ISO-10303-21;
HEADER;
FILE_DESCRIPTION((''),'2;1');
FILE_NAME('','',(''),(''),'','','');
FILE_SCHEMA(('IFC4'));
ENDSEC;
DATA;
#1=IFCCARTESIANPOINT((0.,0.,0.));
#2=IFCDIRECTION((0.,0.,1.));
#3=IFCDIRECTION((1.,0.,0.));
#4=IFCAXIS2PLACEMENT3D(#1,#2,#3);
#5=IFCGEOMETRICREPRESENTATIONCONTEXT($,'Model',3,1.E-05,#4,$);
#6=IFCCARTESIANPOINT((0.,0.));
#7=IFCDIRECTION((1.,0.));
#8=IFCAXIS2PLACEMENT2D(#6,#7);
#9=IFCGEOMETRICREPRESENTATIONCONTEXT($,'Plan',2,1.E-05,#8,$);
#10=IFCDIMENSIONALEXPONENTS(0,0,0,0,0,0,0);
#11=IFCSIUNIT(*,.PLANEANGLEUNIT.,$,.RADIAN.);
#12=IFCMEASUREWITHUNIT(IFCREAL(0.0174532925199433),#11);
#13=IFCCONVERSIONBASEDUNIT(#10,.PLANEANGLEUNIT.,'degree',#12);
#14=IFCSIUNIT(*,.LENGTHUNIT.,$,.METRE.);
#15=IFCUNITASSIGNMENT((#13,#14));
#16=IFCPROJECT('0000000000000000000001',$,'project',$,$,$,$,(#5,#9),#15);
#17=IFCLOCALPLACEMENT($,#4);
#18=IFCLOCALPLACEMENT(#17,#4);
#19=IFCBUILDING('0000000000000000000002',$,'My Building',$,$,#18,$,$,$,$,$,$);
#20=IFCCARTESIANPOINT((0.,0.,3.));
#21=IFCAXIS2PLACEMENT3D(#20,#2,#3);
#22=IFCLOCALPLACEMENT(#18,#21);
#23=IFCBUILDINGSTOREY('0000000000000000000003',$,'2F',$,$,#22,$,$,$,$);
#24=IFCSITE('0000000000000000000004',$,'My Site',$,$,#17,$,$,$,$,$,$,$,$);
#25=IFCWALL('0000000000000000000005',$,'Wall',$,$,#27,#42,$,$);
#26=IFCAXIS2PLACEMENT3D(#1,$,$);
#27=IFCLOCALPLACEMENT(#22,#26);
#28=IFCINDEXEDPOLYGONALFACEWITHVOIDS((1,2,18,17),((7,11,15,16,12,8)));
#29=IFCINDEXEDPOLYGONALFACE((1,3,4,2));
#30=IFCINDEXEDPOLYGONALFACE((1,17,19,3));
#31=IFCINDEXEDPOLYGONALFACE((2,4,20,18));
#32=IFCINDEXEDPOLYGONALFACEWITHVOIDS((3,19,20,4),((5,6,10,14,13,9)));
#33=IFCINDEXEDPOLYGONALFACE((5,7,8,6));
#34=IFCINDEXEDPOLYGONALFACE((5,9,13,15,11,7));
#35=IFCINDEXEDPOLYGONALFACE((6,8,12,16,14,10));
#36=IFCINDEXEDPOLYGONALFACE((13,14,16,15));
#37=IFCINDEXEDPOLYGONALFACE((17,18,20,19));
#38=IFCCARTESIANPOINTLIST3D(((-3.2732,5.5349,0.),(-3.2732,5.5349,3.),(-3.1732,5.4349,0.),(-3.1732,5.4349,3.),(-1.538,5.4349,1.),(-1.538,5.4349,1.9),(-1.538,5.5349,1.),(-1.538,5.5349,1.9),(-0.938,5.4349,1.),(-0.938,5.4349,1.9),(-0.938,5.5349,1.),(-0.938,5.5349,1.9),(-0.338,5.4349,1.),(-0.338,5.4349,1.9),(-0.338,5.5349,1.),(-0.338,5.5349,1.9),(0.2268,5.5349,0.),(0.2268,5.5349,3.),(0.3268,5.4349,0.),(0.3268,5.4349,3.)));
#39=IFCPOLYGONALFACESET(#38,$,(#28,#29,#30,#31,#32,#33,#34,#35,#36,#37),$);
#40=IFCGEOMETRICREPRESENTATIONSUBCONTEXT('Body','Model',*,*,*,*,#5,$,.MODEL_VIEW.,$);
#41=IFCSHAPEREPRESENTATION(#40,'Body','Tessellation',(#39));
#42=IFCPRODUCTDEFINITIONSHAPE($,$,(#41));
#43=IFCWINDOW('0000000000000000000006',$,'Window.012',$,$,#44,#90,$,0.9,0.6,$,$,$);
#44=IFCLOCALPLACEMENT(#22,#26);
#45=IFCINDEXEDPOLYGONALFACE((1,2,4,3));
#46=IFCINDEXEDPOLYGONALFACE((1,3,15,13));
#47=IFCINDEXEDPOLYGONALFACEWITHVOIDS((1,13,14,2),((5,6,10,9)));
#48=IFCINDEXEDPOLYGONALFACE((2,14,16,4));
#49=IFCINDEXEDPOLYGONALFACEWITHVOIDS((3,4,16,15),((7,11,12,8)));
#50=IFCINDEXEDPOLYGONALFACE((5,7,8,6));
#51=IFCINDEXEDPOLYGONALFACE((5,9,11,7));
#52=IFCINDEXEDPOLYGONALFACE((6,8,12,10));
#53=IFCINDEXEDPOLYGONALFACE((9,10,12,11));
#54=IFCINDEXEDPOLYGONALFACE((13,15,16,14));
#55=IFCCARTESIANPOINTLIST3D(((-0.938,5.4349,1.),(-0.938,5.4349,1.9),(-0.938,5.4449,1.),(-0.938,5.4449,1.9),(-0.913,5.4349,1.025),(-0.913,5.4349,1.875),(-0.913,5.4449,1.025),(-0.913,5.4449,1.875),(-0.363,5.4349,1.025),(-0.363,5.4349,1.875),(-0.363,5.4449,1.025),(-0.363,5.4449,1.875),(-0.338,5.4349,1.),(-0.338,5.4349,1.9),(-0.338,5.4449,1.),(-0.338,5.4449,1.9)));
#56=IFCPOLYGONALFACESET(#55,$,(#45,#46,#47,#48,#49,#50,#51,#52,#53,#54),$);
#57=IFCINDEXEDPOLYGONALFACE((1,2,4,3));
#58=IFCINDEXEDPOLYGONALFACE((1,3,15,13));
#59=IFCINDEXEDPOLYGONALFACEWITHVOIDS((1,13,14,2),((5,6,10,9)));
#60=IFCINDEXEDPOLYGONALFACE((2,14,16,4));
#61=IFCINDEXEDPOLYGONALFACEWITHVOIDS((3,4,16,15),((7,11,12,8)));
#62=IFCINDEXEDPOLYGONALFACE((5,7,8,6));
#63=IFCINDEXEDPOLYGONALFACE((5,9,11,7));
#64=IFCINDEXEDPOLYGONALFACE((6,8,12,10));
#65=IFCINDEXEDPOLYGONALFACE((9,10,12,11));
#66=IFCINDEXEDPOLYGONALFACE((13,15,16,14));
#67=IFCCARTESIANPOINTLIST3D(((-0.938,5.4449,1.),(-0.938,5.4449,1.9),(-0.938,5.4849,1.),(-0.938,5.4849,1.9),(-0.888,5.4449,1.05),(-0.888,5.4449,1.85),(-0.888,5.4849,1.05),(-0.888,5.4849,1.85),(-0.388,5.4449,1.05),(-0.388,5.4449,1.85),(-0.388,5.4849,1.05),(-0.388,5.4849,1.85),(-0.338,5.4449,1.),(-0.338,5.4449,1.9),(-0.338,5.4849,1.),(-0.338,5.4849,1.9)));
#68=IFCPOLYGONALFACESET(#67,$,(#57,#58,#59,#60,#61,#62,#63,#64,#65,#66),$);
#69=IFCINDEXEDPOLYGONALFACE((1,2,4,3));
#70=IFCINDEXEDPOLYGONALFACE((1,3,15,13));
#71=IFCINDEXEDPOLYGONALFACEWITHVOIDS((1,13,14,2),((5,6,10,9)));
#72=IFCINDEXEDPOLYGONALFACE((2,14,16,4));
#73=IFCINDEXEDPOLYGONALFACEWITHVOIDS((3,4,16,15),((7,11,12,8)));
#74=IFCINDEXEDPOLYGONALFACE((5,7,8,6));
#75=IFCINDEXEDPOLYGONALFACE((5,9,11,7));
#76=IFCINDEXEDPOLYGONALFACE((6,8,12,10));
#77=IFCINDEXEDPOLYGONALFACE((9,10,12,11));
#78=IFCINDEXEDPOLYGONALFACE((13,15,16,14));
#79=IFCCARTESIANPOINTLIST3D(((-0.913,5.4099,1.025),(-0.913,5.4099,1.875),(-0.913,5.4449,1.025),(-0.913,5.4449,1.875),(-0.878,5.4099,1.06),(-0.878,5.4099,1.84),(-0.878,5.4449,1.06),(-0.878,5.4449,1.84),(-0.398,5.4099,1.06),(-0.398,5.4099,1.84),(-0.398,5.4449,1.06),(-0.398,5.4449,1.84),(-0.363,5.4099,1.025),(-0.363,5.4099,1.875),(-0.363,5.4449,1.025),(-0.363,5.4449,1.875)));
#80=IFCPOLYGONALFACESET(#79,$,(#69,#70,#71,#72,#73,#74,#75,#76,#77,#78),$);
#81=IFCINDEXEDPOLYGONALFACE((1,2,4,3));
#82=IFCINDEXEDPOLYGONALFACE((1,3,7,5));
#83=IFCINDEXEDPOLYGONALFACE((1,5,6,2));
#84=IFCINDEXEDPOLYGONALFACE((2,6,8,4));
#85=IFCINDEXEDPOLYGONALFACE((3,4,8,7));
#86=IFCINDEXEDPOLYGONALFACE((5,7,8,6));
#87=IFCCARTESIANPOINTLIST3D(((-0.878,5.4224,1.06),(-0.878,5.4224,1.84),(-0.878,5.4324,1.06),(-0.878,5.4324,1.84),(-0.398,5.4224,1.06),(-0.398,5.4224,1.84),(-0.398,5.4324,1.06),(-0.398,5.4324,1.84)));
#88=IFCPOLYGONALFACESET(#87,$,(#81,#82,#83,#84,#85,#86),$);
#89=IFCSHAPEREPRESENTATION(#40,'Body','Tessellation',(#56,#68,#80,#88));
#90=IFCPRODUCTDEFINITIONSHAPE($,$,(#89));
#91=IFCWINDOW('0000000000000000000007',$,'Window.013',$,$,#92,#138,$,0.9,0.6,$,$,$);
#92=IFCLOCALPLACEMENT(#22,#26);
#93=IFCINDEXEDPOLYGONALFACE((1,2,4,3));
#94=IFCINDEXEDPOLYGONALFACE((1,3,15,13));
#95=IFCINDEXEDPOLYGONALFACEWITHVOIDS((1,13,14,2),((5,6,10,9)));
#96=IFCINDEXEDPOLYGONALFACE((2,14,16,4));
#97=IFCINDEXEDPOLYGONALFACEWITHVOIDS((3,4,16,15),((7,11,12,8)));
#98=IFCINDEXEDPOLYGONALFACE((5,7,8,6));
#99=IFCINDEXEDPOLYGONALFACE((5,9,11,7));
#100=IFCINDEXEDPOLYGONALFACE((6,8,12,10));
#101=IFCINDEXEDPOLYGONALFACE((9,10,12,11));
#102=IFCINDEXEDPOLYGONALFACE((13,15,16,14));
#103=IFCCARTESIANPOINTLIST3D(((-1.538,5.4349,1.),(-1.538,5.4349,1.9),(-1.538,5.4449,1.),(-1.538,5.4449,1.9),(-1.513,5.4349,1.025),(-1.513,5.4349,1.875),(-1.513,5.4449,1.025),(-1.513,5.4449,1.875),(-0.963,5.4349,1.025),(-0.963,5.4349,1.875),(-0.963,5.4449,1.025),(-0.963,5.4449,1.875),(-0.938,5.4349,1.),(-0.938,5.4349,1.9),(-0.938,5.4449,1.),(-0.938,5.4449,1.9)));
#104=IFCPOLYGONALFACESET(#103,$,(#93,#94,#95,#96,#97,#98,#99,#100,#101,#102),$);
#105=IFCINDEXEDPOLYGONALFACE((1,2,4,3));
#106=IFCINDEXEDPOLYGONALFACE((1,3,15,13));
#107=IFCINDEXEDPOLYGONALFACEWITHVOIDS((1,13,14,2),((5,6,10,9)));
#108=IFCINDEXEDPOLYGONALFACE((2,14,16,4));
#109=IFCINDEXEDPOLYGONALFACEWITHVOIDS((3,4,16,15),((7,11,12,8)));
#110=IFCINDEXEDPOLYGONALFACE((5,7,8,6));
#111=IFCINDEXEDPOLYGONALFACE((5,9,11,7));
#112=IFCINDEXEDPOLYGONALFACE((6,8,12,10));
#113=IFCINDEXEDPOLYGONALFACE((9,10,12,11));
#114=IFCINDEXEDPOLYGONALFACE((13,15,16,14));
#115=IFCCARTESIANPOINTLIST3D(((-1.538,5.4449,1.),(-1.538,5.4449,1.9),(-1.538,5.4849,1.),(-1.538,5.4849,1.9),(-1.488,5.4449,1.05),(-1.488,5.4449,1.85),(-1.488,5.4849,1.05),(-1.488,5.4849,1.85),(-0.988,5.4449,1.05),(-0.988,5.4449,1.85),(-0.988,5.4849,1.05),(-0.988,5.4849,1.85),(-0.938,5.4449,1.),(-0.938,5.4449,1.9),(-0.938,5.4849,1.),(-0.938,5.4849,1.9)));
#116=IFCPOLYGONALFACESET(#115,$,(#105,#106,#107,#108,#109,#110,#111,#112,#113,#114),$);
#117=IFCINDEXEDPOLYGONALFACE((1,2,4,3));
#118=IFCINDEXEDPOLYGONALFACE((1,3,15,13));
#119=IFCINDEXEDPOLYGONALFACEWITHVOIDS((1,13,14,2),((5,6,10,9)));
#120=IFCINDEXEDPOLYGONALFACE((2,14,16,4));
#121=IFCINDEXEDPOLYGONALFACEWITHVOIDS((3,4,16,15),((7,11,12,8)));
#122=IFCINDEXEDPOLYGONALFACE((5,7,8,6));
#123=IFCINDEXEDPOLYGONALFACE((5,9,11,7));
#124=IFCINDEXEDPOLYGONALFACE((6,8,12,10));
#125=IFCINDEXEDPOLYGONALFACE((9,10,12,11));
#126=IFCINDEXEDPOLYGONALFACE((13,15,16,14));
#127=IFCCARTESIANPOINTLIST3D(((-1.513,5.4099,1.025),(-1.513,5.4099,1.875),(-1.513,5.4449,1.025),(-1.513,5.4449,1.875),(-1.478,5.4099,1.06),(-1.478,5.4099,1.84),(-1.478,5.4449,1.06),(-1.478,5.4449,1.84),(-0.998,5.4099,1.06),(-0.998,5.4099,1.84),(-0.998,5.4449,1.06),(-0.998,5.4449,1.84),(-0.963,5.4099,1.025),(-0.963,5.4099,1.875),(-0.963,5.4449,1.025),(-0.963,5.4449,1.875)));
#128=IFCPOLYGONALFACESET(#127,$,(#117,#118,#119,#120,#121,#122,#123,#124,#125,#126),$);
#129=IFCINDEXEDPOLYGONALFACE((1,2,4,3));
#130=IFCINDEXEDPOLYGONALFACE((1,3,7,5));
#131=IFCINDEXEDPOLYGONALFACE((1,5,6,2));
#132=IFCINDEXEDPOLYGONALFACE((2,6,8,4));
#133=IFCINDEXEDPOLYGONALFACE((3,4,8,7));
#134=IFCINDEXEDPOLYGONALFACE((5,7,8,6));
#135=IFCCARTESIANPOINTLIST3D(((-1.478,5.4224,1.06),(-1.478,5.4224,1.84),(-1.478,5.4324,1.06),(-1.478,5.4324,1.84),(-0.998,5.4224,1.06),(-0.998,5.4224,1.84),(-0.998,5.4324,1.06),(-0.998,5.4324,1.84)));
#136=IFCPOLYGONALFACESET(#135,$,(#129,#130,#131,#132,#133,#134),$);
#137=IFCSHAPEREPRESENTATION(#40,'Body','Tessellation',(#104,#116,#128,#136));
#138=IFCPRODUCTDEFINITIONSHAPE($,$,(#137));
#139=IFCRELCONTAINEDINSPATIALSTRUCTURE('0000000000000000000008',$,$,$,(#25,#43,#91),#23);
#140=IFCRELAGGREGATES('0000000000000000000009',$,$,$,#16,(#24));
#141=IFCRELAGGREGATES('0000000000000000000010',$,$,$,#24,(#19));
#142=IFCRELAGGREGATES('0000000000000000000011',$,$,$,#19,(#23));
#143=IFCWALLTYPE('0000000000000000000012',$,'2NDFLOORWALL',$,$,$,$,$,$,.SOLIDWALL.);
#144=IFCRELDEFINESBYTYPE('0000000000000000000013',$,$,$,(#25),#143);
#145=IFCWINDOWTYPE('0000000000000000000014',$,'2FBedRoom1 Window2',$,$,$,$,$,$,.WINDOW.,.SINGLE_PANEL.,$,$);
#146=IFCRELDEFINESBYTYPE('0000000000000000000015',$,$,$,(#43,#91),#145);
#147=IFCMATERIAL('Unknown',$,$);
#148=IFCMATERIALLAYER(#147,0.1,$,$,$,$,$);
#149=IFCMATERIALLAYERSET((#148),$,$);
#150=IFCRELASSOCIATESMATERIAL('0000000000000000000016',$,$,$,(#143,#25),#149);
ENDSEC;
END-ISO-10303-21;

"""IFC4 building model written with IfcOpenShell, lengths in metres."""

from ifc_helpers import new_model, entity, si_unit, converted_unit, frame, origin_with_axes, origin_2d_with_axis, place, context, subcontext, project, spatial, line, indexed_curve, outline, extrude, shape, source, transform, mapped, material, layer, layer_set, layer_usage, type_object, type_shapes, element, fill, save


model = new_model("IFC4")

# Units and contexts
model_context = context("Model", 3, precision=1e-05, world=origin_with_axes())
plan_context = context("Plan", 2, precision=1e-05, world=origin_2d_with_axis())
body_context_1 = subcontext(model_context, "Body", "Model", "MODEL_VIEW")
body_context_2 = subcontext(plan_context, "Body", "Plan", "PLAN_VIEW")
ifc_project = project(units=[converted_unit("PLANEANGLEUNIT", "degree", entity("IfcReal", 0.0174532925199433), si_unit("PLANEANGLEUNIT", "RADIAN"), dimensions=[0, 0, 0, 0, 0, 0, 0]), si_unit("LENGTHUNIT", "METRE")], contexts=[model_context, plan_context])

# Site, building, storey
site_placement = place(None, origin_with_axes())
site = spatial("IfcSite", under=ifc_project, at=site_placement, Name="My Site")
building_placement = place(site_placement, origin_with_axes())
building = spatial("IfcBuilding", under=site, at=building_placement, Name="My Building")
storey_placement = place(building_placement, frame((0.0, 0.0, 3.0), z_axis=(0.0, 0.0, 1.0), x_axis=(1.0, 0.0, 0.0)))
storey = spatial("IfcBuildingStorey", under=building, at=storey_placement, Name="2F")

# Shared definitions
ifc_material = material(Name="Unknown")

# Shared definitions
ifc_layer_1 = layer(ifc_material, 0.1)
ifc_layer_set_1 = layer_set([ifc_layer_1])
wall_type_1 = type_object("IfcWallType", Name="2NDFLOORWALL", PredefinedType="SOLIDWALL", material=ifc_layer_set_1)

# Wall, openings, windows
ifc_layer_usage_1 = layer_usage(ifc_layer_set_1, "AXIS2", "POSITIVE", 0.0)
wall_1_placement = place(storey_placement, frame((0.2268, 5.5349, 0.0), z_axis=(0.0, 0.0, 1.0), x_axis=(-1.0, 0.0, 0.0)))
wall_1 = element("IfcWall", 1, at=wall_1_placement, inside=storey, type_object=wall_type_1, material=ifc_layer_usage_1, Name="Wall", context=body_context_1, shape_type="SweptSolid", body=[
    extrude(outline(indexed_curve([(0.0, 0.0), (-0.1, 0.1), (3.4, 0.1), (3.5, 0.0)], segments=[line(1, 2, 3, 4, 1)])), origin_with_axes(), (0.0, 0.0, 1.0), 3.0),
])
shared_shape_1 = source(origin_with_axes(), body_context_1, "Body", "SweptSolid", [
    extrude(outline(indexed_curve([(0.0, 0.0), (0.6, 0.0), (0.6, 0.9), (0.0, 0.9)], segments=[line(1, 2, 3, 4, 1)])), frame((0.0, -0.6, 0.0), z_axis=(0.0, -1.0, 0.0), x_axis=(1.0, 0.0, 0.0)), (0.0, 0.0, -1.0), 1.2),
])
opening_1_placement = place(wall_1_placement, frame((0.5648, 0.0, 1.0), z_axis=(0.0, 0.0, 1.0), x_axis=(1.0, 0.0, 0.0)))
opening_1 = element("IfcOpeningElement", 2, at=opening_1_placement, cuts=wall_1, PredefinedType="OPENING", context=body_context_1, shape_type="MappedRepresentation", body=[
    mapped(shared_shape_1, transform((0.0, 0.0, 0.0), x_axis=(1.0, 0.0, 0.0), y_axis=(0.0, 1.0, 0.0), z_axis=(0.0, 0.0, 1.0), scale=1.0)),
])
opening_2_placement = place(wall_1_placement, frame((1.1648, 0.0, 1.0), z_axis=(0.0, 0.0, 1.0), x_axis=(1.0, 0.0, 0.0)))
opening_2 = element("IfcOpeningElement", 3, at=opening_2_placement, cuts=wall_1, PredefinedType="OPENING", context=body_context_1, shape_type="MappedRepresentation", body=[
    mapped(shared_shape_1, transform((0.0, 0.0, 0.0), x_axis=(1.0, 0.0, 0.0), y_axis=(0.0, 1.0, 0.0), z_axis=(0.0, 0.0, 1.0), scale=1.0)),
])
window_type_1 = type_object("IfcWindowType", Name="2FBedRoom1 Window2", PartitioningType="SINGLE_PANEL", PredefinedType="WINDOW")
shared_shape_2 = source(origin_with_axes(), body_context_1, "Body", "SweptSolid", [
    extrude(outline(indexed_curve([(0.0, 0.0), (0.6, 0.0), (0.6, 0.9), (0.0, 0.9)], segments=[line(1, 2, 3, 4, 1)]), holes=[indexed_curve([(0.025, 0.025), (0.575, 0.025), (0.575, 0.875), (0.025, 0.875)], segments=[line(1, 2, 3, 4, 1)])]), frame((0.0, 0.09, 0.0), z_axis=(0.0, -1.0, 0.0), x_axis=(1.0, 0.0, 0.0)), (0.0, 0.0, -1.0), 0.01),
    extrude(outline(indexed_curve([(0.0, 0.0), (0.6, 0.0), (0.6, 0.9), (0.0, 0.9)], segments=[line(1, 2, 3, 4, 1)]), holes=[indexed_curve([(0.05, 0.05), (0.55, 0.05), (0.55, 0.85), (0.05, 0.85)], segments=[line(1, 2, 3, 4, 1)])]), frame((0.0, 0.05, 0.0), z_axis=(0.0, -1.0, 0.0), x_axis=(1.0, 0.0, 0.0)), (0.0, 0.0, -1.0), 0.04),
    extrude(outline(indexed_curve([(0.0, 0.0), (0.55, 0.0), (0.55, 0.85), (0.0, 0.85)], segments=[line(1, 2, 3, 4, 1)]), holes=[indexed_curve([(0.035, 0.035), (0.515, 0.035), (0.515, 0.815), (0.035, 0.815)], segments=[line(1, 2, 3, 4, 1)])]), frame((0.025, 0.09, 0.025), z_axis=(0.0, -1.0, 0.0), x_axis=(1.0, 0.0, 0.0)), (0.0, 0.0, -1.0), 0.035),
    extrude(outline(indexed_curve([(0.035, 0.035), (0.515, 0.035), (0.515, 0.815), (0.035, 0.815)], segments=[line(1, 2, 3, 4, 1)])), frame((0.025, 0.1025, 0.025), z_axis=(0.0, -1.0, 0.0), x_axis=(1.0, 0.0, 0.0)), (0.0, 0.0, -1.0), 0.01),
])
shared_shape_3 = source(origin_with_axes(), body_context_2, "Body", "Curve2D", [
    entity("IfcIndexedPolyCurve", entity("IfcCartesianPointList2D", [[0.05, 0.05], [0.55, 0.05]])),
    entity("IfcIndexedPolyCurve", entity("IfcCartesianPointList2D", [[0.0, 0.1], [0.025, 0.1], [0.025, 0.09], [0.05, 0.09], [0.05, 0.05], [0.0, 0.05]]), [entity("IfcLineIndex", [1, 2, 3, 4, 5, 6, 1])]),
    entity("IfcIndexedPolyCurve", entity("IfcCartesianPointList2D", [[0.6, 0.1], [0.575, 0.1], [0.575, 0.09], [0.55, 0.09], [0.55, 0.05], [0.6, 0.05]]), [entity("IfcLineIndex", [1, 2, 3, 4, 5, 6, 1])]),
    entity("IfcIndexedPolyCurve", entity("IfcCartesianPointList2D", [[0.025, 0.09], [0.06, 0.09], [0.06, 0.125], [0.025, 0.125]]), [entity("IfcLineIndex", [1, 2, 3, 4, 1])]),
    entity("IfcIndexedPolyCurve", entity("IfcCartesianPointList2D", [[0.575, 0.09], [0.54, 0.09], [0.54, 0.125], [0.575, 0.125]]), [entity("IfcLineIndex", [1, 2, 3, 4, 1])]),
    entity("IfcIndexedPolyCurve", entity("IfcCartesianPointList2D", [[0.06, 0.09], [0.54, 0.09]])),
    entity("IfcIndexedPolyCurve", entity("IfcCartesianPointList2D", [[0.06, 0.125], [0.54, 0.125]])),
    entity("IfcIndexedPolyCurve", entity("IfcCartesianPointList2D", [[0.06, 0.1075], [0.54, 0.1075]])),
])
type_shapes(window_type_1, [shared_shape_2, shared_shape_3])
window_1_placement = place(opening_1_placement, frame((0.0, 0.0, 0.0), z_axis=(0.0, 0.0, 1.0), x_axis=(1.0, 0.0, 0.0)))
window_1 = element("IfcWindow", 4, at=window_1_placement, inside=storey, type_object=window_type_1, Name="Window.012", OverallHeight=0.9, OverallWidth=0.6, shapes=[
    shape(body_context_1, "Body", "MappedRepresentation", [mapped(shared_shape_2, transform((0.0, 0.0, 0.0), x_axis=(1.0, 0.0, 0.0), y_axis=(0.0, 1.0, 0.0), z_axis=(0.0, 0.0, 1.0), scale=1.0))]),
    shape(body_context_2, "Body", "MappedRepresentation", [mapped(shared_shape_3, transform((0.0, 0.0, 0.0), x_axis=(1.0, 0.0, 0.0), y_axis=(0.0, 1.0, 0.0), z_axis=(0.0, 0.0, 1.0), scale=1.0))]),
])
fill(opening_1, window_1)
window_2_placement = place(opening_2_placement, frame((0.0, 0.0, 0.0), z_axis=(0.0, 0.0, 1.0), x_axis=(1.0, 0.0, 0.0)))
window_2 = element("IfcWindow", 5, at=window_2_placement, inside=storey, type_object=window_type_1, Name="Window.013", OverallHeight=0.9, OverallWidth=0.6, shapes=[
    shape(body_context_1, "Body", "MappedRepresentation", [mapped(shared_shape_2, transform((0.0, 0.0, 0.0), x_axis=(1.0, 0.0, 0.0), y_axis=(0.0, 1.0, 0.0), z_axis=(0.0, 0.0, 1.0), scale=1.0))]),
    shape(body_context_2, "Body", "MappedRepresentation", [mapped(shared_shape_3, transform((0.0, 0.0, 0.0), x_axis=(1.0, 0.0, 0.0), y_axis=(0.0, 1.0, 0.0), z_axis=(0.0, 0.0, 1.0), scale=1.0))]),
])
fill(opening_2, window_2)

save(model, "model.ifc")
